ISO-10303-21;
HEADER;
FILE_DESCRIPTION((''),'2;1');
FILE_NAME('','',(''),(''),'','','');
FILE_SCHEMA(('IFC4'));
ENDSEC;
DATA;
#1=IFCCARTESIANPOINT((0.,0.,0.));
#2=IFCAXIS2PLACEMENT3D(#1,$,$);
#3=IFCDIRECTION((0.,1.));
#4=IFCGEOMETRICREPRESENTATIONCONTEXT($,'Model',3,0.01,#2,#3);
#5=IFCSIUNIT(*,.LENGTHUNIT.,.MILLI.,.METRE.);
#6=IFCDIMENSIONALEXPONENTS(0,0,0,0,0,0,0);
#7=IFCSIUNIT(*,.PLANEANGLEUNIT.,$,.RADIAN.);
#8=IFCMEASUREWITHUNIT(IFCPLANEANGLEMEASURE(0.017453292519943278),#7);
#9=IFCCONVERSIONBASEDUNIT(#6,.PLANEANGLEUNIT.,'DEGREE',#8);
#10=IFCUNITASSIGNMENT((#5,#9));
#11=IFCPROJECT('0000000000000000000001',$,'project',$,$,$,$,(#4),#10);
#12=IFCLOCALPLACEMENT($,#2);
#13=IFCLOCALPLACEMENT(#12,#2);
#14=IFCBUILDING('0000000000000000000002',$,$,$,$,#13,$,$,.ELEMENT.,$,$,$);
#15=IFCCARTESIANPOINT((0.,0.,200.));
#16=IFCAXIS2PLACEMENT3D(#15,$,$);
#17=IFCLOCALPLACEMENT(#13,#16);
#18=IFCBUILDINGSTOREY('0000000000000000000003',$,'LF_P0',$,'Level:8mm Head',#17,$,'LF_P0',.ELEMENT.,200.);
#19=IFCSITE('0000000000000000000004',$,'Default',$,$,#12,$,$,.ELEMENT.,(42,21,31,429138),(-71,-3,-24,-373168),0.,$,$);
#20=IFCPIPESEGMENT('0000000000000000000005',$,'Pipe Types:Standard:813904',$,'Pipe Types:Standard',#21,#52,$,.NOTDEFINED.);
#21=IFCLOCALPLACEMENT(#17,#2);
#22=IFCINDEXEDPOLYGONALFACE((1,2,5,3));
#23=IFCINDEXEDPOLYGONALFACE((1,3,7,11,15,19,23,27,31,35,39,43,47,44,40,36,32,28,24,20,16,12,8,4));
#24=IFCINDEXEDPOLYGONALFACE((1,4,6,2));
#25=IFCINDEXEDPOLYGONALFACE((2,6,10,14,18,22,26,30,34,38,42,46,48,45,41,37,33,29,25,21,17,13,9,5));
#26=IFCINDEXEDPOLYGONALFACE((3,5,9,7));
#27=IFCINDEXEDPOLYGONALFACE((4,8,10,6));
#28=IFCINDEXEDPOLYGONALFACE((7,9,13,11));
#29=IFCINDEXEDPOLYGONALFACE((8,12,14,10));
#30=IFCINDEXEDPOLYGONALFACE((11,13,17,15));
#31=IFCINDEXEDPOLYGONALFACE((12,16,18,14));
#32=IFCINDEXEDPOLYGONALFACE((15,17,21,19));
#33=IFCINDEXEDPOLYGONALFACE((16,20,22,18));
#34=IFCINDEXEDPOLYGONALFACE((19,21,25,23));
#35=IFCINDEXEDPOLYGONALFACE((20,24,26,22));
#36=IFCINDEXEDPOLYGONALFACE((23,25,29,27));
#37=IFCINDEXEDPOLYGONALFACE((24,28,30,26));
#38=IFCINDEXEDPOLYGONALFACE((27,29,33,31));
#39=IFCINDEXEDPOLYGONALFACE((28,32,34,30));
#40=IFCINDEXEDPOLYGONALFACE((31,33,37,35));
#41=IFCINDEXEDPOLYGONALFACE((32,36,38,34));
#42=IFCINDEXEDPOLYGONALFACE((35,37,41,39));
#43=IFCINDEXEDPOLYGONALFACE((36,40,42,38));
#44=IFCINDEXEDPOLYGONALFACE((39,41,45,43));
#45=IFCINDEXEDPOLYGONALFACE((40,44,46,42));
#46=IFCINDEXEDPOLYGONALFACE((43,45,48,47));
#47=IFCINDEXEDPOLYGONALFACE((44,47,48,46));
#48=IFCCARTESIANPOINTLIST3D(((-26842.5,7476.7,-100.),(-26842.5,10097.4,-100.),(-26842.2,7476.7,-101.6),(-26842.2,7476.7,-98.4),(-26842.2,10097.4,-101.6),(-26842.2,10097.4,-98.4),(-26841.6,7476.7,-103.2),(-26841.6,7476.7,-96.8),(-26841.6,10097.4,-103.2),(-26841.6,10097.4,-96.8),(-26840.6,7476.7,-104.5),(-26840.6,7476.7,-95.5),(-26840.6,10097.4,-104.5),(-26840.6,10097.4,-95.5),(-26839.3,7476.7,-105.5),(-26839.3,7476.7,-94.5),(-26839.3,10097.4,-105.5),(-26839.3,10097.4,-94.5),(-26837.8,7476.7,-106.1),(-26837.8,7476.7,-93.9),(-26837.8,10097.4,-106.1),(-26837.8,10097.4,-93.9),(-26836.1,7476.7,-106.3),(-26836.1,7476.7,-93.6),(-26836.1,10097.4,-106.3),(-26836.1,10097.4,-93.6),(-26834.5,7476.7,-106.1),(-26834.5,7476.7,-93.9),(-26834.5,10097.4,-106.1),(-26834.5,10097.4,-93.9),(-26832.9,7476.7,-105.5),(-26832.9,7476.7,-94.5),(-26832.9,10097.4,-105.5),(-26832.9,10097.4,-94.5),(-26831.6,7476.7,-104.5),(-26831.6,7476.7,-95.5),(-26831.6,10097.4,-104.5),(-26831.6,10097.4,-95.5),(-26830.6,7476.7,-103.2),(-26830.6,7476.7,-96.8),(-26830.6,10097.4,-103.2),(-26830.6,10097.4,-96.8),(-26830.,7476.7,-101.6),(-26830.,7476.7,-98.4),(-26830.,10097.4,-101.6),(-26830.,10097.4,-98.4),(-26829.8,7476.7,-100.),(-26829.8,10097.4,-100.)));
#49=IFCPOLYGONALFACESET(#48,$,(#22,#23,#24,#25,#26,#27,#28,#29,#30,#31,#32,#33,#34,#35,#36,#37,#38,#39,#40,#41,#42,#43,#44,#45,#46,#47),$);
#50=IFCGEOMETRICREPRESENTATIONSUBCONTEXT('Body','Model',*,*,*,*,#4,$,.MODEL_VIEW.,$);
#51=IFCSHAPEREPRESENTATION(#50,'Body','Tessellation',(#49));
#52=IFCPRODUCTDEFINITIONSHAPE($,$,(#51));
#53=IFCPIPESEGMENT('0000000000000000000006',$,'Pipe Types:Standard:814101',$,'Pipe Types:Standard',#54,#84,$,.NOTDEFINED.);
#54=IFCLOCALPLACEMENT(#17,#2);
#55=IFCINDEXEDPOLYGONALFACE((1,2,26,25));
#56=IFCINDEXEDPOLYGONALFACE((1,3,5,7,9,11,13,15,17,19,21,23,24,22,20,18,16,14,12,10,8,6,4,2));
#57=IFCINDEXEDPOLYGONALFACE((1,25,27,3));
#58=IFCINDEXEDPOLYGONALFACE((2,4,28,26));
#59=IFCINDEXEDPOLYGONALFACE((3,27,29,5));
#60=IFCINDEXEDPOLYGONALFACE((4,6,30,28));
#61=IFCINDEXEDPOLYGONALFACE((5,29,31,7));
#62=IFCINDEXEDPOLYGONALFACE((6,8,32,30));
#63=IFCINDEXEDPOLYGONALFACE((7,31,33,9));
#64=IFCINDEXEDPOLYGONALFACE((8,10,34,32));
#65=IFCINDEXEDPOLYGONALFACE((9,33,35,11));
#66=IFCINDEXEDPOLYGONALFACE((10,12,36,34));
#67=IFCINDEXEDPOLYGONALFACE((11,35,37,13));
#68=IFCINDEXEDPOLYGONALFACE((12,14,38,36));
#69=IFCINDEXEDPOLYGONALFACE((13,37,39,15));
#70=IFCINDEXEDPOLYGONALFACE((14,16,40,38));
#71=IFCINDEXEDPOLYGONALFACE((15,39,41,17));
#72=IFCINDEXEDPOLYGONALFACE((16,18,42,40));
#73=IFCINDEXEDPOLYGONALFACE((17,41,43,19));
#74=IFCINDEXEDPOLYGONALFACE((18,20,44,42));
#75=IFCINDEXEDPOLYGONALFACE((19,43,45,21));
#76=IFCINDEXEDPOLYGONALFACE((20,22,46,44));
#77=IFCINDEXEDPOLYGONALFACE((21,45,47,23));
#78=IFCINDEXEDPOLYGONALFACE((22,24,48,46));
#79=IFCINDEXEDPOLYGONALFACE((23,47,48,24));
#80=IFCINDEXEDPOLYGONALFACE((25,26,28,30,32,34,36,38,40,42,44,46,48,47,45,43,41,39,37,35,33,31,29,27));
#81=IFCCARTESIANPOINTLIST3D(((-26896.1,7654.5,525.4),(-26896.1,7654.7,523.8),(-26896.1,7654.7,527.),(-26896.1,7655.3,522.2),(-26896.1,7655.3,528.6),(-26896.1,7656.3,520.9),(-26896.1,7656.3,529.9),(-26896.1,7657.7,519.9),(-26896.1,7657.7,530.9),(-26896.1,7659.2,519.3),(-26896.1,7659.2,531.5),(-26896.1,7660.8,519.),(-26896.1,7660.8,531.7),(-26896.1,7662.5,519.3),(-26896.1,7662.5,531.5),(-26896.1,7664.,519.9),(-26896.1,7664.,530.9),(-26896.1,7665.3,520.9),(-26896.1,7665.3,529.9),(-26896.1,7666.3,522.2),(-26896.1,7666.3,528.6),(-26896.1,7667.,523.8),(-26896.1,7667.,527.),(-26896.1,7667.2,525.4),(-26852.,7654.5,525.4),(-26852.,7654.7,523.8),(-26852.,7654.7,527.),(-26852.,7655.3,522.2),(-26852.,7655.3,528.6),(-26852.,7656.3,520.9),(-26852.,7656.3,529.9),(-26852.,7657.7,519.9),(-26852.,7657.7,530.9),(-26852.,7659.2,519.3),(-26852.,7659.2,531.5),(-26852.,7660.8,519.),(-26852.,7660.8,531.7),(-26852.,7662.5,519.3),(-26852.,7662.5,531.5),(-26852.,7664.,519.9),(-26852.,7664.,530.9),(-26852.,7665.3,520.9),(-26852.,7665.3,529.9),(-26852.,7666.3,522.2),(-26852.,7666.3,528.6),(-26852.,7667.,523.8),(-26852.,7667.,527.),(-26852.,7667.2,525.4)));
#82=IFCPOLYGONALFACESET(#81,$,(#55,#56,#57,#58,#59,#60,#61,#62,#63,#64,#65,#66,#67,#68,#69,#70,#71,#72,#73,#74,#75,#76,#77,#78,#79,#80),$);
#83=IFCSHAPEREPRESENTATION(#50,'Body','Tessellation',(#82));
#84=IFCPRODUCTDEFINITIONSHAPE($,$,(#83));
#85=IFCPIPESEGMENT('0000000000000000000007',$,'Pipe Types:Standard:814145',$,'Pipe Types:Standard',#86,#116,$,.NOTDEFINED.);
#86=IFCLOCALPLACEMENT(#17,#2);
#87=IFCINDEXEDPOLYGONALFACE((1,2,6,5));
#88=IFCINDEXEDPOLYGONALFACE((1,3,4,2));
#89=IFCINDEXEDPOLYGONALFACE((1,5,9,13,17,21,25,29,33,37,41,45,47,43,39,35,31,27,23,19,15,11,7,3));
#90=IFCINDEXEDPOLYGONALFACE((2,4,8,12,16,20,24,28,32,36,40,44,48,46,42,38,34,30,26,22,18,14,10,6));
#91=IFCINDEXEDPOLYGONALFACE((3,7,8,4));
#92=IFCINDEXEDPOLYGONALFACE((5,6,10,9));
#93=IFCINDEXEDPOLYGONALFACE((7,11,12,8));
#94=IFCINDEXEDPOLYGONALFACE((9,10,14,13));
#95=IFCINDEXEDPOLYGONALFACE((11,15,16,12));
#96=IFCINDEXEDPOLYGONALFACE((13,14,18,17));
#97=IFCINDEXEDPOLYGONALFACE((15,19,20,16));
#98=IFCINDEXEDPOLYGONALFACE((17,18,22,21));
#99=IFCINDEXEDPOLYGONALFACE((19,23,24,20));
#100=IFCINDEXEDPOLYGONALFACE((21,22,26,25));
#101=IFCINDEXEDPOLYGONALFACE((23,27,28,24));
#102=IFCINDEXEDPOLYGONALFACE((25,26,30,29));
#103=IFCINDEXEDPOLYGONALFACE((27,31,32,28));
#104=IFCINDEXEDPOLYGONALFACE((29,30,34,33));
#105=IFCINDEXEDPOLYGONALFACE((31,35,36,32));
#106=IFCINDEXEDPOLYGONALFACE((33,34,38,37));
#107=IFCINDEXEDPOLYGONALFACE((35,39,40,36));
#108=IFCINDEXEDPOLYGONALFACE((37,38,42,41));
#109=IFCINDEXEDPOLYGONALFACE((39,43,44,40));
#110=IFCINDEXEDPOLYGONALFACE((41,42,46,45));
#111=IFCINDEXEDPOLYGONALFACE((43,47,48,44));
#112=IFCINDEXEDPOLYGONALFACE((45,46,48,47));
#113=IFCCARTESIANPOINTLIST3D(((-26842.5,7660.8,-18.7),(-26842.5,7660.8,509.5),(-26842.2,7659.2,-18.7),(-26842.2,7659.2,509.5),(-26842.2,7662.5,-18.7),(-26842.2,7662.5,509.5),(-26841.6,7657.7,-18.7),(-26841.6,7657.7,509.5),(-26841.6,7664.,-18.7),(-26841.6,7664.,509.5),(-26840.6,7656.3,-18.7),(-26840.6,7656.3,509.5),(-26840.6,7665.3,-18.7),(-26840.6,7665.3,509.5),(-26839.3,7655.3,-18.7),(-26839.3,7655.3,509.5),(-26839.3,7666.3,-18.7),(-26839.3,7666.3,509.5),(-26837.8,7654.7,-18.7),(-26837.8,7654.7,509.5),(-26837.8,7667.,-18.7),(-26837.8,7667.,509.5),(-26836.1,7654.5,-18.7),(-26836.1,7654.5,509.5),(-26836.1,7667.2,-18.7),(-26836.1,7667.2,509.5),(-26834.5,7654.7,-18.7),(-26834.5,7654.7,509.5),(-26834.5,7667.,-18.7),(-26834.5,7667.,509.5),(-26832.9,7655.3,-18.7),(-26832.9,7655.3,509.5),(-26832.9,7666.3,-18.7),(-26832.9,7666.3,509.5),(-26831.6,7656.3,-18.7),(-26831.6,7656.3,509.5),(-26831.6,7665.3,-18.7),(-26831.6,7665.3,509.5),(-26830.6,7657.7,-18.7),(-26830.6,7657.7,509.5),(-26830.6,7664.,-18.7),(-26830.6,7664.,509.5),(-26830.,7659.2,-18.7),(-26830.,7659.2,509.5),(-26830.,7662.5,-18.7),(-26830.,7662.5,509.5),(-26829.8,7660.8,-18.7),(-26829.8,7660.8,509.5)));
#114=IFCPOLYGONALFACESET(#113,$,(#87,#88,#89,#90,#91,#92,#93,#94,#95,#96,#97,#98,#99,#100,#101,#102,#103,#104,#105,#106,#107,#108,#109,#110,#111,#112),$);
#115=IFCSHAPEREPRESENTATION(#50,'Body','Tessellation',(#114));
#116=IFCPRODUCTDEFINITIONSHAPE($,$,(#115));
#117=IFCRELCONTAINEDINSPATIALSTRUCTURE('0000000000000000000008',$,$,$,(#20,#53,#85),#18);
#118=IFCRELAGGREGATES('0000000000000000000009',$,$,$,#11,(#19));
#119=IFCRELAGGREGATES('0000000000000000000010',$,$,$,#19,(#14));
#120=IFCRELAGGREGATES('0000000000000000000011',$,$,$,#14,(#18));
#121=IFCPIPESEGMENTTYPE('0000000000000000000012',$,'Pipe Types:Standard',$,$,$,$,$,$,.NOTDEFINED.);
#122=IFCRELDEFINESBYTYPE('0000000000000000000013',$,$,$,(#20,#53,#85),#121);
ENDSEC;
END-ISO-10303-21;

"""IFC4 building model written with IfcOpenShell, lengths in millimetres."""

from ifc_helpers import new_model, entity, si_unit, converted_unit, direction, frame, origin, place, context, subcontext, project, spatial, arc, indexed_curve, outline, extrude, type_object, element, save


model = new_model("IFC4")

# Units and contexts
model_context = context("Model", 3, precision=0.01, world=origin(), true_north=direction((0.0, 1.0)))
body_context = subcontext(model_context, "Body", "Model", "MODEL_VIEW")
ifc_project = project(units=[si_unit("LENGTHUNIT", "METRE", prefix="MILLI"), converted_unit("PLANEANGLEUNIT", "DEGREE", entity("IfcPlaneAngleMeasure", 0.017453292519943278), si_unit("PLANEANGLEUNIT", "RADIAN"), dimensions=[0, 0, 0, 0, 0, 0, 0])], contexts=[model_context])

# Site, building, storey
site_placement = place(None, origin())
site = spatial("IfcSite", under=ifc_project, at=site_placement, Name="Default", CompositionType="ELEMENT", RefLatitude=(42, 21, 31, 429138), RefLongitude=(-71, -3, -24, -373168), RefElevation=0.0)
building_placement = place(site_placement, origin())
building = spatial("IfcBuilding", under=site, at=building_placement, CompositionType="ELEMENT")
storey_placement = place(building_placement, frame((0.0, 0.0, 200.0)))
storey = spatial("IfcBuildingStorey", under=building, at=storey_placement, Name="LF_P0", ObjectType="Level:8mm Head", LongName="LF_P0", CompositionType="ELEMENT", Elevation=200.0)

# Pipe segments
pipe_segment_type_1 = type_object("IfcPipeSegmentType", Name="Pipe Types:Standard", PredefinedType="NOTDEFINED")
pipe_segment_1_placement = place(storey_placement, origin())
element("IfcPipeSegment", 1, at=pipe_segment_1_placement, inside=storey, type_object=pipe_segment_type_1, Name="Pipe Types:Standard:813904", ObjectType="Pipe Types:Standard", PredefinedType="NOTDEFINED", context=body_context, shape_type="SweptSolid", body=[
    extrude(outline(indexed_curve([(6.3, 0.0), (4.5, 4.5), (0.0, 6.3), (-4.5, 4.5), (-6.3, 0.0), (-4.5, -4.5), (0.0, -6.4), (4.5, -4.5)], segments=[arc(1, 2, 3), arc(3, 4, 5), arc(5, 6, 7), arc(7, 8, 1)], self_intersect=False)), frame((-26836.1, 7476.7, -100.0), z_axis=(0.0, 1.0, 0.0), x_axis=(1.0, 0.0, 0.0)), (0.0, 0.0, 1.0), 2620.7),
])
pipe_segment_2_placement = place(storey_placement, origin())
element("IfcPipeSegment", 2, at=pipe_segment_2_placement, inside=storey, type_object=pipe_segment_type_1, Name="Pipe Types:Standard:814101", ObjectType="Pipe Types:Standard", PredefinedType="NOTDEFINED", context=body_context, shape_type="SweptSolid", body=[
    extrude(outline(indexed_curve([(6.3, 0.0), (4.5, 4.5), (0.0, 6.4), (-4.5, 4.5), (-6.3, 0.0), (-4.5, -4.5), (0.0, -6.4), (4.5, -4.5)], segments=[arc(1, 2, 3), arc(3, 4, 5), arc(5, 6, 7), arc(7, 8, 1)], self_intersect=False)), frame((-26896.1, 7660.8, 525.4), z_axis=(1.0, 0.0, 0.0), x_axis=(0.0, -1.0, 0.0)), (0.0, 0.0, 1.0), 44.1),
])
pipe_segment_3_placement = place(storey_placement, origin())
element("IfcPipeSegment", 3, at=pipe_segment_3_placement, inside=storey, type_object=pipe_segment_type_1, Name="Pipe Types:Standard:814145", ObjectType="Pipe Types:Standard", PredefinedType="NOTDEFINED", context=body_context, shape_type="SweptSolid", body=[
    extrude(outline(indexed_curve([(6.3, 0.0), (4.5, 4.5), (0.0, 6.3), (-4.5, 4.5), (-6.3, 0.0), (-4.5, -4.5), (0.0, -6.3), (4.5, -4.5)], segments=[arc(1, 2, 3), arc(3, 4, 5), arc(5, 6, 7), arc(7, 8, 1)], self_intersect=False)), frame((-26836.1, 7660.8, -18.7)), (0.0, 0.0, 1.0), 528.2),
])

save(model, "model.ifc")
